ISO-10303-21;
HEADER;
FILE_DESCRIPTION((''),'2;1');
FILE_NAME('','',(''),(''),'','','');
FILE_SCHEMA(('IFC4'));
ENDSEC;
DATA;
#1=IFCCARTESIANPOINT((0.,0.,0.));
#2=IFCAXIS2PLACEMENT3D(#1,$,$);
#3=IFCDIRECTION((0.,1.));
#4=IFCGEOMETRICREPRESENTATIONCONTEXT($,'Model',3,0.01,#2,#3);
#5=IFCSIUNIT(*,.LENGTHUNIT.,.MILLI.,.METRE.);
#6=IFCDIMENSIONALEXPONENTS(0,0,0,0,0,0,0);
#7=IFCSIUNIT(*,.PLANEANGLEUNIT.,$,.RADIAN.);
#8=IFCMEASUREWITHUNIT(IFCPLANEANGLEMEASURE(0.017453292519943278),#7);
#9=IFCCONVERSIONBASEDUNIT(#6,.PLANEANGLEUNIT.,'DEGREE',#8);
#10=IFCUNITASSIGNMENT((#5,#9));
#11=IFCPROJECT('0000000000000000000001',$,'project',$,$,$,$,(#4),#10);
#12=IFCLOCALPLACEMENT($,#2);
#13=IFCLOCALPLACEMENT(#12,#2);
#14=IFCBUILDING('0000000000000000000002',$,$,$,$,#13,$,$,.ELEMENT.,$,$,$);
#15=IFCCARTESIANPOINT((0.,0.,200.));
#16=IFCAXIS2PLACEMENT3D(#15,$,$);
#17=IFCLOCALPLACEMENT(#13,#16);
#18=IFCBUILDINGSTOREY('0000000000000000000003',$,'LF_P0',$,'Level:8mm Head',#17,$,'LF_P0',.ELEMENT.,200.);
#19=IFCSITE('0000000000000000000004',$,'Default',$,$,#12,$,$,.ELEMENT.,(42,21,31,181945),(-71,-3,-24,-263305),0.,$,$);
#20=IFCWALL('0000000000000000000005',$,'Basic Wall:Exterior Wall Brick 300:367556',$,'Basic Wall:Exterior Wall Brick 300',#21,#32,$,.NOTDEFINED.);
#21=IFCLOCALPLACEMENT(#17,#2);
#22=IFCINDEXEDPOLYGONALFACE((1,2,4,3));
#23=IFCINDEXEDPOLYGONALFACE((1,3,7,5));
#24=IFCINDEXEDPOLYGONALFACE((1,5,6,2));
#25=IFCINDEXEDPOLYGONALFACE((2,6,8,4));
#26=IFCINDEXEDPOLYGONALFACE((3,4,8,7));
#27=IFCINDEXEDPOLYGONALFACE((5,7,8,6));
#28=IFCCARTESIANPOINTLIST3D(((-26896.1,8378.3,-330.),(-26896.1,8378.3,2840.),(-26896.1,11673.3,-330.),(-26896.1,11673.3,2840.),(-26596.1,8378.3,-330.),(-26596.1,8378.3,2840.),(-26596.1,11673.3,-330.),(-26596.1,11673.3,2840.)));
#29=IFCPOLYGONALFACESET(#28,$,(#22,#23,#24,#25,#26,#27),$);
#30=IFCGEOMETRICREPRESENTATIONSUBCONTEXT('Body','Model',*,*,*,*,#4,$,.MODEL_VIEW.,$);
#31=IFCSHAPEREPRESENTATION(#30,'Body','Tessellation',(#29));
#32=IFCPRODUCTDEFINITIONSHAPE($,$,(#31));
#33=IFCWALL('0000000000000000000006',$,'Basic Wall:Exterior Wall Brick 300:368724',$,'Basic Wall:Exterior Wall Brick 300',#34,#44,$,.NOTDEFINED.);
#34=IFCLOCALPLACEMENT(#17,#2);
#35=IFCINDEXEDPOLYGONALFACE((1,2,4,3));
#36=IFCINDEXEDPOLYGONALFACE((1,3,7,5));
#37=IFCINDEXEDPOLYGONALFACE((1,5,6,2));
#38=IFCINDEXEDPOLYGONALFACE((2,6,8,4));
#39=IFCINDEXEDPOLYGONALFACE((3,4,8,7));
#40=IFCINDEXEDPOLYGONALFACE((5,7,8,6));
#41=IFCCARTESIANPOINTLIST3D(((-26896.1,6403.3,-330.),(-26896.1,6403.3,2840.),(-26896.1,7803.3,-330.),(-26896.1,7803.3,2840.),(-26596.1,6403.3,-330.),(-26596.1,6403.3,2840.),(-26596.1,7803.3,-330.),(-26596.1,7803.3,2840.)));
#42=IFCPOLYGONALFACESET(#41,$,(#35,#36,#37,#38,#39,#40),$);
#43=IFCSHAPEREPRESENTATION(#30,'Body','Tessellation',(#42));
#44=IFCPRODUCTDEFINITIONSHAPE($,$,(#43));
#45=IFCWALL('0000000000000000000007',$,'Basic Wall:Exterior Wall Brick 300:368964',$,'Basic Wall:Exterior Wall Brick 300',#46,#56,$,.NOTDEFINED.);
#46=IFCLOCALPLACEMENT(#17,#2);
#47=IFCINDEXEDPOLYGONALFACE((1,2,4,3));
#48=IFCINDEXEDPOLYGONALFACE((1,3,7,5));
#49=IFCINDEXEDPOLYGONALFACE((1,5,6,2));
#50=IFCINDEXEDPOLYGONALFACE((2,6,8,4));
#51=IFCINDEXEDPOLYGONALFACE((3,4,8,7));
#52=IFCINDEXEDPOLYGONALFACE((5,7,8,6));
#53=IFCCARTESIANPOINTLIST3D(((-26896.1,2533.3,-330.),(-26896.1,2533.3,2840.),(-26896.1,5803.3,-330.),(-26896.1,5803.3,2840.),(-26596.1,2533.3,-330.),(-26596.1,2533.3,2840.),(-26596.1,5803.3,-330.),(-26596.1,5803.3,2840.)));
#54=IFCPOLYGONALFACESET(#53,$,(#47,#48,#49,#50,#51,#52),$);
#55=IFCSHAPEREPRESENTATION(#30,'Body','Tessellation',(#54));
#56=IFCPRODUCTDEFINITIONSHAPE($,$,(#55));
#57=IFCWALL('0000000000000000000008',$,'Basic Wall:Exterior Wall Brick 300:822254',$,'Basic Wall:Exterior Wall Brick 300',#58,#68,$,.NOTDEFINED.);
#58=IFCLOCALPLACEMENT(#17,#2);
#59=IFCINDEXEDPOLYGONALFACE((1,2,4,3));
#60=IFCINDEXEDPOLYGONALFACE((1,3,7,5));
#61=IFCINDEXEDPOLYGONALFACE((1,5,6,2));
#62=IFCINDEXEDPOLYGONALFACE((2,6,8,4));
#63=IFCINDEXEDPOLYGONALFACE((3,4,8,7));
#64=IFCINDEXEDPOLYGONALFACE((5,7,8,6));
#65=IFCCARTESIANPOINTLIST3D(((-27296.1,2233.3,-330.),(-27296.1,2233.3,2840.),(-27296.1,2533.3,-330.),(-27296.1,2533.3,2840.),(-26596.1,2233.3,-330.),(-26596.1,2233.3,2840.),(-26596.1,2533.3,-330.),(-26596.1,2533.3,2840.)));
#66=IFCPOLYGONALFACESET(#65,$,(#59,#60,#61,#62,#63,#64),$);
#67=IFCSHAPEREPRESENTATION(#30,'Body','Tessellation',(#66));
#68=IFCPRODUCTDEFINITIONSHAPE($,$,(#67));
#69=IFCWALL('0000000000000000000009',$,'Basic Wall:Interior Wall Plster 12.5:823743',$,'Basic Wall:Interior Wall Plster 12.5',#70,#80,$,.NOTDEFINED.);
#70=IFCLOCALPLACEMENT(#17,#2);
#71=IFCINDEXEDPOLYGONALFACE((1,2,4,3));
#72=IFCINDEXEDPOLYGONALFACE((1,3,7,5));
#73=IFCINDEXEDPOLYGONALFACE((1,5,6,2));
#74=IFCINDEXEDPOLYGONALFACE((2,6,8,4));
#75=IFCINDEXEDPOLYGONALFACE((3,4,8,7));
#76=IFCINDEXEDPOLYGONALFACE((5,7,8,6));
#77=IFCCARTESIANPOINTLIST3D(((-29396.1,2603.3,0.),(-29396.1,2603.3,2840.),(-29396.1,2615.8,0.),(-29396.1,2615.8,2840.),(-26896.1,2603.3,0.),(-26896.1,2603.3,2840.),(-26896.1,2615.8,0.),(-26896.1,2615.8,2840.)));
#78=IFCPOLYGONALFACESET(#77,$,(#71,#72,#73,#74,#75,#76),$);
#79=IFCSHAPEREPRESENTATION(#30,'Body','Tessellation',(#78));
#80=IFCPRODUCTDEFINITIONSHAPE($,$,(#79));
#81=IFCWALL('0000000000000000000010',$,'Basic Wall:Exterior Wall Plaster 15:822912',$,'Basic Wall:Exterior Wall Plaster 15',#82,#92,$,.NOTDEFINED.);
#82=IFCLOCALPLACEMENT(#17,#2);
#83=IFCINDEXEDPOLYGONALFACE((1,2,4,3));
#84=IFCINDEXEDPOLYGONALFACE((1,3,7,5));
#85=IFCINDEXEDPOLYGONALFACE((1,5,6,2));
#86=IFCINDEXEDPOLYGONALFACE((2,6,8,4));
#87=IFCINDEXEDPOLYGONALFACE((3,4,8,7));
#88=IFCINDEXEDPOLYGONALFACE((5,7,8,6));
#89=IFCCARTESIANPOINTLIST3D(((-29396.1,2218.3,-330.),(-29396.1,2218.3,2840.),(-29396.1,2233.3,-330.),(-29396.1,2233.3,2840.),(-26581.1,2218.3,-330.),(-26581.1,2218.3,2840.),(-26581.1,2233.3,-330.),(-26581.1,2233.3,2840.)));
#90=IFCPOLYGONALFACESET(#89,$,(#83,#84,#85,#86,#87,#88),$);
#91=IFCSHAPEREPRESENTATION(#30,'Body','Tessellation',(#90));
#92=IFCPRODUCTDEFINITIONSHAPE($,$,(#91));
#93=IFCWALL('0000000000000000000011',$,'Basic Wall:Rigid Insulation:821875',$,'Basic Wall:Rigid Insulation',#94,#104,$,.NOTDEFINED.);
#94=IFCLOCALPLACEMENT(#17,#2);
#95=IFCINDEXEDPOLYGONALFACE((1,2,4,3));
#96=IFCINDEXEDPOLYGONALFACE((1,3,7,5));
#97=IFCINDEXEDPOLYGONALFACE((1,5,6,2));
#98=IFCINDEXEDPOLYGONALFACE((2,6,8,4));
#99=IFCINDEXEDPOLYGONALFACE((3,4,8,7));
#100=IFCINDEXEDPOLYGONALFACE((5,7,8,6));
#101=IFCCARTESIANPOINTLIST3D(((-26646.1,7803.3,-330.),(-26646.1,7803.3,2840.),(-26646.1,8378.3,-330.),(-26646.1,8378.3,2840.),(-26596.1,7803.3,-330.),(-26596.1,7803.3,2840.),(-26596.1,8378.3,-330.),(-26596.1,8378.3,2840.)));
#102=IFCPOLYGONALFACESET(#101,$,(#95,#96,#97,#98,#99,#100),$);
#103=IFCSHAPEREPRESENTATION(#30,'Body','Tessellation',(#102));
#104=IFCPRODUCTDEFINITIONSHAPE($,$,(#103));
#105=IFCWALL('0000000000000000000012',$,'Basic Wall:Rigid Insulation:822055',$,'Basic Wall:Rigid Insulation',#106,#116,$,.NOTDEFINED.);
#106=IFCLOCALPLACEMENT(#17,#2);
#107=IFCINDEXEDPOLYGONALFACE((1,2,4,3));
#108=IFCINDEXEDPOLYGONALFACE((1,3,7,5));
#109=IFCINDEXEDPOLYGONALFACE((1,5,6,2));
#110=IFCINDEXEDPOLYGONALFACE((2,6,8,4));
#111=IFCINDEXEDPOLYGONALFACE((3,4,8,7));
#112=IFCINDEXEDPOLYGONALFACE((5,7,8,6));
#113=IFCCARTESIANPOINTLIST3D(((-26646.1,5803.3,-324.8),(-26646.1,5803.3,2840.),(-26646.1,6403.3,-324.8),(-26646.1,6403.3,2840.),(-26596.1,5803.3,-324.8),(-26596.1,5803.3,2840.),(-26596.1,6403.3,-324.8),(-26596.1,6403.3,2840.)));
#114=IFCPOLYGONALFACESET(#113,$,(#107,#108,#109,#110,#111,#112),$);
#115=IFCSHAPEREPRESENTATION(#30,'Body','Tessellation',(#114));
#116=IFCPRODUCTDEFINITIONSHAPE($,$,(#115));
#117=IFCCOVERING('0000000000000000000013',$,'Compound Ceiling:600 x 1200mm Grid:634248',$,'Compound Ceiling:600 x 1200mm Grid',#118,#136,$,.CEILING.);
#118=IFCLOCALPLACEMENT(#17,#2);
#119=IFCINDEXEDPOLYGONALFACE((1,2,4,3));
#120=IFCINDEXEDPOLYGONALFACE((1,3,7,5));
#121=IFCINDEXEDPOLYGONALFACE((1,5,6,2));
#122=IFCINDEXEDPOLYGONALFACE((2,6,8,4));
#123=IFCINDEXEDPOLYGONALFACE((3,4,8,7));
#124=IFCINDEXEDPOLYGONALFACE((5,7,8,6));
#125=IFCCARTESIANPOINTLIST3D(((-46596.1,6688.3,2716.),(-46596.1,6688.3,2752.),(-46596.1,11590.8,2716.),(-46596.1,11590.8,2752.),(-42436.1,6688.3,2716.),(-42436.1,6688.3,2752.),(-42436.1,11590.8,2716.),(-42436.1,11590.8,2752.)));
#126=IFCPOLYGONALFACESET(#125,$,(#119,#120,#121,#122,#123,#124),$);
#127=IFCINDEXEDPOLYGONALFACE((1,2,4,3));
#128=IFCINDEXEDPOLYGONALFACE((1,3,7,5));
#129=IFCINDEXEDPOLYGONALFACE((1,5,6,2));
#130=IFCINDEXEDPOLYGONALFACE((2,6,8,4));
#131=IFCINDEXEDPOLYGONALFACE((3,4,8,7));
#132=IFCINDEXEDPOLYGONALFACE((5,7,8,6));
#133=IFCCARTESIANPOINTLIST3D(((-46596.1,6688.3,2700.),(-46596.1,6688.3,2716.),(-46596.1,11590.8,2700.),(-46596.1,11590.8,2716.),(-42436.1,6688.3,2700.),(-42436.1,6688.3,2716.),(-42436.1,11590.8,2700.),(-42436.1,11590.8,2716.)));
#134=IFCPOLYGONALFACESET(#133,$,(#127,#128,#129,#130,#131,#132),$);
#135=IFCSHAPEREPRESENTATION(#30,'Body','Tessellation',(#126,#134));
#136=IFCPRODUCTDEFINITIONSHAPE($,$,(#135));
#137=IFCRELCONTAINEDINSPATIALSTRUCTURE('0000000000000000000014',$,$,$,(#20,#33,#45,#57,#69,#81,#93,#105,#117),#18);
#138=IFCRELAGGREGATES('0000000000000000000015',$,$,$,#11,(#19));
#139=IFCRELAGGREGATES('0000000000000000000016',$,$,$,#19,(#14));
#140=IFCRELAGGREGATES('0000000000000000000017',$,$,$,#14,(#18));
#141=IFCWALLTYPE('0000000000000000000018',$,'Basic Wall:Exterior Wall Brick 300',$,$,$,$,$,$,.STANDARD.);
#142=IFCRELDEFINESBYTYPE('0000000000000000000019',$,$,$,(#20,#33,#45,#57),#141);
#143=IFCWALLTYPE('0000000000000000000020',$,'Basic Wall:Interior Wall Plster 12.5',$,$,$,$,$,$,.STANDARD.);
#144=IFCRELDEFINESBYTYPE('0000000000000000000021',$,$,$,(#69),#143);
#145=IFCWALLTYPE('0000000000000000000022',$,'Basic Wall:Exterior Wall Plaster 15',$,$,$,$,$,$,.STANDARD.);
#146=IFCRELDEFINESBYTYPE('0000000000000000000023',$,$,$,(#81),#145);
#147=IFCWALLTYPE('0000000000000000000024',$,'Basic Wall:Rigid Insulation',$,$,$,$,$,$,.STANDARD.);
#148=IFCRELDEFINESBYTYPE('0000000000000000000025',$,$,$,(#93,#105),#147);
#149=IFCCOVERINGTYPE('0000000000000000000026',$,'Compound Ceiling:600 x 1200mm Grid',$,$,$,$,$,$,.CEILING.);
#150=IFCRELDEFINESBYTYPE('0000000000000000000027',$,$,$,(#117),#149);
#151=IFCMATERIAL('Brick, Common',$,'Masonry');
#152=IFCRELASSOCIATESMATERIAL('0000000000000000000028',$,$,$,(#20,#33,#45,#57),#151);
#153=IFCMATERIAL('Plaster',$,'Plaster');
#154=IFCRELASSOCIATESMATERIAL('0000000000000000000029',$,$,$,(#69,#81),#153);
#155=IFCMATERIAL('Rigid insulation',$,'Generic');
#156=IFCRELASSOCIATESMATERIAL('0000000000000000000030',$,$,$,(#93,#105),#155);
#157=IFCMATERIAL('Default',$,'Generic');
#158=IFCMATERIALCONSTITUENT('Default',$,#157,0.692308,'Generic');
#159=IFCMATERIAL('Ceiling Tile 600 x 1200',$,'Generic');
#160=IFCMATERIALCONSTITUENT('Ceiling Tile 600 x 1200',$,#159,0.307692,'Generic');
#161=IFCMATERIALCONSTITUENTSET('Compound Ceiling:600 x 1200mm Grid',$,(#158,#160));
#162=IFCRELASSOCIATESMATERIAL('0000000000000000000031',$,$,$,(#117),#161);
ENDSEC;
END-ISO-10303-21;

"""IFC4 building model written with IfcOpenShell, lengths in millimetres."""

from ifc_helpers import new_model, entity, si_unit, converted_unit, direction, frame, origin, place, context, subcontext, project, spatial, indexed_curve, outline, extrude, material, constituent, constituent_set, type_object, element, save


model = new_model("IFC4")

# Units and contexts
model_context = context("Model", 3, precision=0.01, world=origin(), true_north=direction((0.0, 1.0)))
body_context = subcontext(model_context, "Body", "Model", "MODEL_VIEW")
ifc_project = project(units=[si_unit("LENGTHUNIT", "METRE", prefix="MILLI"), converted_unit("PLANEANGLEUNIT", "DEGREE", entity("IfcPlaneAngleMeasure", 0.017453292519943278), si_unit("PLANEANGLEUNIT", "RADIAN"), dimensions=[0, 0, 0, 0, 0, 0, 0])], contexts=[model_context])

# Site, building, storey
site_placement = place(None, origin())
site = spatial("IfcSite", under=ifc_project, at=site_placement, Name="Default", CompositionType="ELEMENT", RefLatitude=(42, 21, 31, 181945), RefLongitude=(-71, -3, -24, -263305), RefElevation=0.0)
building_placement = place(site_placement, origin())
building = spatial("IfcBuilding", under=site, at=building_placement, CompositionType="ELEMENT")
storey_placement = place(building_placement, frame((0.0, 0.0, 200.0)))
storey = spatial("IfcBuildingStorey", under=building, at=storey_placement, Name="LF_P0", ObjectType="Level:8mm Head", LongName="LF_P0", CompositionType="ELEMENT", Elevation=200.0)

# Walls
ifc_material_1 = material(Name="Brick, Common", Category="Masonry")
wall_type_1 = type_object("IfcWallType", Name="Basic Wall:Exterior Wall Brick 300", PredefinedType="STANDARD")
wall_1_placement = place(storey_placement, frame((-26746.1, 11673.3, -330.0), z_axis=(0.0, 0.0, 1.0), x_axis=(0.0, -1.0, 0.0)))
element("IfcWall", 1, at=wall_1_placement, inside=storey, type_object=wall_type_1, material=ifc_material_1, Name="Basic Wall:Exterior Wall Brick 300:367556", ObjectType="Basic Wall:Exterior Wall Brick 300", PredefinedType="NOTDEFINED", context=body_context, shape_type="SweptSolid", body=[
    extrude(outline(indexed_curve([(3295.0, 150.0), (0.0, 150.0), (0.0, -150.0), (3295.0, -150.0), (3295.0, 150.0)], self_intersect=False)), origin(), (0.0, 0.0, 1.0), 3170.0),
])
wall_2_placement = place(storey_placement, frame((-26746.1, 7803.3, -330.0), z_axis=(0.0, 0.0, 1.0), x_axis=(0.0, -1.0, 0.0)))
element("IfcWall", 2, at=wall_2_placement, inside=storey, type_object=wall_type_1, material=ifc_material_1, Name="Basic Wall:Exterior Wall Brick 300:368724", ObjectType="Basic Wall:Exterior Wall Brick 300", PredefinedType="NOTDEFINED", context=body_context, shape_type="SweptSolid", body=[
    extrude(outline(indexed_curve([(1400.0, 150.0), (0.0, 150.0), (0.0, -150.0), (1400.0, -150.0), (1400.0, 150.0)], self_intersect=False)), origin(), (0.0, 0.0, 1.0), 3170.0),
])
wall_3_placement = place(storey_placement, frame((-26746.1, 5803.3, -330.0), z_axis=(0.0, 0.0, 1.0), x_axis=(0.0, -1.0, 0.0)))
element("IfcWall", 3, at=wall_3_placement, inside=storey, type_object=wall_type_1, material=ifc_material_1, Name="Basic Wall:Exterior Wall Brick 300:368964", ObjectType="Basic Wall:Exterior Wall Brick 300", PredefinedType="NOTDEFINED", context=body_context, shape_type="SweptSolid", body=[
    extrude(outline(indexed_curve([(3270.0, 150.0), (0.0, 150.0), (0.0, -150.0), (3270.0, -150.0), (3270.0, 150.0)], self_intersect=False)), origin(), (0.0, 0.0, 1.0), 3170.0),
])
wall_4_placement = place(storey_placement, frame((-26596.1, 2383.3, -330.0), z_axis=(0.0, 0.0, 1.0), x_axis=(-1.0, 0.0, 0.0)))
element("IfcWall", 4, at=wall_4_placement, inside=storey, type_object=wall_type_1, material=ifc_material_1, Name="Basic Wall:Exterior Wall Brick 300:822254", ObjectType="Basic Wall:Exterior Wall Brick 300", PredefinedType="NOTDEFINED", context=body_context, shape_type="SweptSolid", body=[
    extrude(outline(indexed_curve([(700.0, 150.0), (0.0, 150.0), (0.0, -150.0), (700.0, -150.0), (700.0, 150.0)], self_intersect=False)), origin(), (0.0, 0.0, 1.0), 3170.0),
])
ifc_material_2 = material(Name="Plaster", Category="Plaster")
wall_type_2 = type_object("IfcWallType", Name="Basic Wall:Interior Wall Plster 12.5", PredefinedType="STANDARD")
wall_5_placement = place(storey_placement, frame((-26896.1, 2609.6, 0.0), z_axis=(0.0, 0.0, 1.0), x_axis=(-1.0, 0.0, 0.0)))
element("IfcWall", 5, at=wall_5_placement, inside=storey, type_object=wall_type_2, material=ifc_material_2, Name="Basic Wall:Interior Wall Plster 12.5:823743", ObjectType="Basic Wall:Interior Wall Plster 12.5", PredefinedType="NOTDEFINED", context=body_context, shape_type="SweptSolid", body=[
    extrude(outline(indexed_curve([(2500.0, 6.3), (0.0, 6.3), (0.0, -6.3), (2500.0, -6.3), (2500.0, 6.3)], self_intersect=False)), origin(), (0.0, 0.0, 1.0), 2840.0),
])
wall_type_3 = type_object("IfcWallType", Name="Basic Wall:Exterior Wall Plaster 15", PredefinedType="STANDARD")
wall_6_placement = place(storey_placement, frame((-26581.1, 2225.8, -330.0), z_axis=(0.0, 0.0, 1.0), x_axis=(-1.0, 0.0, 0.0)))
element("IfcWall", 6, at=wall_6_placement, inside=storey, type_object=wall_type_3, material=ifc_material_2, Name="Basic Wall:Exterior Wall Plaster 15:822912", ObjectType="Basic Wall:Exterior Wall Plaster 15", PredefinedType="NOTDEFINED", context=body_context, shape_type="SweptSolid", body=[
    extrude(outline(indexed_curve([(2815.0, 7.5), (0.0, 7.5), (0.0, -7.5), (2815.0, -7.5), (2815.0, 7.5)], self_intersect=False)), origin(), (0.0, 0.0, 1.0), 3170.0),
])
ifc_material_3 = material(Name="Rigid insulation", Category="Generic")
wall_type_4 = type_object("IfcWallType", Name="Basic Wall:Rigid Insulation", PredefinedType="STANDARD")
wall_7_placement = place(storey_placement, frame((-26621.1, 8378.3, -330.0), z_axis=(0.0, 0.0, 1.0), x_axis=(0.0, -1.0, 0.0)))
element("IfcWall", 7, at=wall_7_placement, inside=storey, type_object=wall_type_4, material=ifc_material_3, Name="Basic Wall:Rigid Insulation:821875", ObjectType="Basic Wall:Rigid Insulation", PredefinedType="NOTDEFINED", context=body_context, shape_type="SweptSolid", body=[
    extrude(outline(indexed_curve([(575.0, 25.0), (0.0, 25.0), (0.0, -25.0), (575.0, -25.0), (575.0, 25.0)], self_intersect=False)), origin(), (0.0, 0.0, 1.0), 3170.0),
])
wall_8_placement = place(storey_placement, frame((-26621.1, 6403.3, -324.8), z_axis=(0.0, 0.0, 1.0), x_axis=(0.0, -1.0, 0.0)))
element("IfcWall", 8, at=wall_8_placement, inside=storey, type_object=wall_type_4, material=ifc_material_3, Name="Basic Wall:Rigid Insulation:822055", ObjectType="Basic Wall:Rigid Insulation", PredefinedType="NOTDEFINED", context=body_context, shape_type="SweptSolid", body=[
    extrude(outline(indexed_curve([(600.0, 25.0), (0.0, 25.0), (0.0, -25.0), (600.0, -25.0), (600.0, 25.0)], self_intersect=False)), origin(), (0.0, 0.0, 1.0), 3164.8),
])

# Covering
ifc_material_4 = material(Name="Default", Category="Generic")
ifc_constituent_1 = constituent(ifc_material_4, Name="Default", Category="Generic", fraction=0.692308)
ifc_material_5 = material(Name="Ceiling Tile 600 x 1200", Category="Generic")
ifc_constituent_2 = constituent(ifc_material_5, Name="Ceiling Tile 600 x 1200", Category="Generic", fraction=0.307692)
ifc_constituent_set = constituent_set(constituents=[ifc_constituent_1, ifc_constituent_2], Name="Compound Ceiling:600 x 1200mm Grid")
covering_type = type_object("IfcCoveringType", Name="Compound Ceiling:600 x 1200mm Grid", PredefinedType="CEILING")
covering_placement = place(storey_placement, origin())
element("IfcCovering", 9, at=covering_placement, inside=storey, type_object=covering_type, material=ifc_constituent_set, Name="Compound Ceiling:600 x 1200mm Grid:634248", ObjectType="Compound Ceiling:600 x 1200mm Grid", PredefinedType="CEILING", context=body_context, shape_type="SweptSolid", body=[
    extrude(outline(indexed_curve([(-2080.0, -2451.3), (2080.0, -2451.3), (2080.0, 2451.3), (-2080.0, 2451.3), (-2080.0, -2451.3)], self_intersect=False)), frame((-44516.1, 9139.6, 2716.0), z_axis=(0.0, 0.0, 1.0), x_axis=(-1.0, 0.0, 0.0)), (0.0, 0.0, 1.0), 36.0),
    extrude(outline(indexed_curve([(-2451.3, -2080.0), (2451.3, -2080.0), (2451.3, 2080.0), (-2451.3, 2080.0), (-2451.3, -2080.0)], self_intersect=False)), frame((-44516.1, 9139.6, 2700.0), z_axis=(0.0, 0.0, 1.0), x_axis=(0.0, 1.0, 0.0)), (0.0, 0.0, 1.0), 16.0),
])

save(model, "model.ifc")
